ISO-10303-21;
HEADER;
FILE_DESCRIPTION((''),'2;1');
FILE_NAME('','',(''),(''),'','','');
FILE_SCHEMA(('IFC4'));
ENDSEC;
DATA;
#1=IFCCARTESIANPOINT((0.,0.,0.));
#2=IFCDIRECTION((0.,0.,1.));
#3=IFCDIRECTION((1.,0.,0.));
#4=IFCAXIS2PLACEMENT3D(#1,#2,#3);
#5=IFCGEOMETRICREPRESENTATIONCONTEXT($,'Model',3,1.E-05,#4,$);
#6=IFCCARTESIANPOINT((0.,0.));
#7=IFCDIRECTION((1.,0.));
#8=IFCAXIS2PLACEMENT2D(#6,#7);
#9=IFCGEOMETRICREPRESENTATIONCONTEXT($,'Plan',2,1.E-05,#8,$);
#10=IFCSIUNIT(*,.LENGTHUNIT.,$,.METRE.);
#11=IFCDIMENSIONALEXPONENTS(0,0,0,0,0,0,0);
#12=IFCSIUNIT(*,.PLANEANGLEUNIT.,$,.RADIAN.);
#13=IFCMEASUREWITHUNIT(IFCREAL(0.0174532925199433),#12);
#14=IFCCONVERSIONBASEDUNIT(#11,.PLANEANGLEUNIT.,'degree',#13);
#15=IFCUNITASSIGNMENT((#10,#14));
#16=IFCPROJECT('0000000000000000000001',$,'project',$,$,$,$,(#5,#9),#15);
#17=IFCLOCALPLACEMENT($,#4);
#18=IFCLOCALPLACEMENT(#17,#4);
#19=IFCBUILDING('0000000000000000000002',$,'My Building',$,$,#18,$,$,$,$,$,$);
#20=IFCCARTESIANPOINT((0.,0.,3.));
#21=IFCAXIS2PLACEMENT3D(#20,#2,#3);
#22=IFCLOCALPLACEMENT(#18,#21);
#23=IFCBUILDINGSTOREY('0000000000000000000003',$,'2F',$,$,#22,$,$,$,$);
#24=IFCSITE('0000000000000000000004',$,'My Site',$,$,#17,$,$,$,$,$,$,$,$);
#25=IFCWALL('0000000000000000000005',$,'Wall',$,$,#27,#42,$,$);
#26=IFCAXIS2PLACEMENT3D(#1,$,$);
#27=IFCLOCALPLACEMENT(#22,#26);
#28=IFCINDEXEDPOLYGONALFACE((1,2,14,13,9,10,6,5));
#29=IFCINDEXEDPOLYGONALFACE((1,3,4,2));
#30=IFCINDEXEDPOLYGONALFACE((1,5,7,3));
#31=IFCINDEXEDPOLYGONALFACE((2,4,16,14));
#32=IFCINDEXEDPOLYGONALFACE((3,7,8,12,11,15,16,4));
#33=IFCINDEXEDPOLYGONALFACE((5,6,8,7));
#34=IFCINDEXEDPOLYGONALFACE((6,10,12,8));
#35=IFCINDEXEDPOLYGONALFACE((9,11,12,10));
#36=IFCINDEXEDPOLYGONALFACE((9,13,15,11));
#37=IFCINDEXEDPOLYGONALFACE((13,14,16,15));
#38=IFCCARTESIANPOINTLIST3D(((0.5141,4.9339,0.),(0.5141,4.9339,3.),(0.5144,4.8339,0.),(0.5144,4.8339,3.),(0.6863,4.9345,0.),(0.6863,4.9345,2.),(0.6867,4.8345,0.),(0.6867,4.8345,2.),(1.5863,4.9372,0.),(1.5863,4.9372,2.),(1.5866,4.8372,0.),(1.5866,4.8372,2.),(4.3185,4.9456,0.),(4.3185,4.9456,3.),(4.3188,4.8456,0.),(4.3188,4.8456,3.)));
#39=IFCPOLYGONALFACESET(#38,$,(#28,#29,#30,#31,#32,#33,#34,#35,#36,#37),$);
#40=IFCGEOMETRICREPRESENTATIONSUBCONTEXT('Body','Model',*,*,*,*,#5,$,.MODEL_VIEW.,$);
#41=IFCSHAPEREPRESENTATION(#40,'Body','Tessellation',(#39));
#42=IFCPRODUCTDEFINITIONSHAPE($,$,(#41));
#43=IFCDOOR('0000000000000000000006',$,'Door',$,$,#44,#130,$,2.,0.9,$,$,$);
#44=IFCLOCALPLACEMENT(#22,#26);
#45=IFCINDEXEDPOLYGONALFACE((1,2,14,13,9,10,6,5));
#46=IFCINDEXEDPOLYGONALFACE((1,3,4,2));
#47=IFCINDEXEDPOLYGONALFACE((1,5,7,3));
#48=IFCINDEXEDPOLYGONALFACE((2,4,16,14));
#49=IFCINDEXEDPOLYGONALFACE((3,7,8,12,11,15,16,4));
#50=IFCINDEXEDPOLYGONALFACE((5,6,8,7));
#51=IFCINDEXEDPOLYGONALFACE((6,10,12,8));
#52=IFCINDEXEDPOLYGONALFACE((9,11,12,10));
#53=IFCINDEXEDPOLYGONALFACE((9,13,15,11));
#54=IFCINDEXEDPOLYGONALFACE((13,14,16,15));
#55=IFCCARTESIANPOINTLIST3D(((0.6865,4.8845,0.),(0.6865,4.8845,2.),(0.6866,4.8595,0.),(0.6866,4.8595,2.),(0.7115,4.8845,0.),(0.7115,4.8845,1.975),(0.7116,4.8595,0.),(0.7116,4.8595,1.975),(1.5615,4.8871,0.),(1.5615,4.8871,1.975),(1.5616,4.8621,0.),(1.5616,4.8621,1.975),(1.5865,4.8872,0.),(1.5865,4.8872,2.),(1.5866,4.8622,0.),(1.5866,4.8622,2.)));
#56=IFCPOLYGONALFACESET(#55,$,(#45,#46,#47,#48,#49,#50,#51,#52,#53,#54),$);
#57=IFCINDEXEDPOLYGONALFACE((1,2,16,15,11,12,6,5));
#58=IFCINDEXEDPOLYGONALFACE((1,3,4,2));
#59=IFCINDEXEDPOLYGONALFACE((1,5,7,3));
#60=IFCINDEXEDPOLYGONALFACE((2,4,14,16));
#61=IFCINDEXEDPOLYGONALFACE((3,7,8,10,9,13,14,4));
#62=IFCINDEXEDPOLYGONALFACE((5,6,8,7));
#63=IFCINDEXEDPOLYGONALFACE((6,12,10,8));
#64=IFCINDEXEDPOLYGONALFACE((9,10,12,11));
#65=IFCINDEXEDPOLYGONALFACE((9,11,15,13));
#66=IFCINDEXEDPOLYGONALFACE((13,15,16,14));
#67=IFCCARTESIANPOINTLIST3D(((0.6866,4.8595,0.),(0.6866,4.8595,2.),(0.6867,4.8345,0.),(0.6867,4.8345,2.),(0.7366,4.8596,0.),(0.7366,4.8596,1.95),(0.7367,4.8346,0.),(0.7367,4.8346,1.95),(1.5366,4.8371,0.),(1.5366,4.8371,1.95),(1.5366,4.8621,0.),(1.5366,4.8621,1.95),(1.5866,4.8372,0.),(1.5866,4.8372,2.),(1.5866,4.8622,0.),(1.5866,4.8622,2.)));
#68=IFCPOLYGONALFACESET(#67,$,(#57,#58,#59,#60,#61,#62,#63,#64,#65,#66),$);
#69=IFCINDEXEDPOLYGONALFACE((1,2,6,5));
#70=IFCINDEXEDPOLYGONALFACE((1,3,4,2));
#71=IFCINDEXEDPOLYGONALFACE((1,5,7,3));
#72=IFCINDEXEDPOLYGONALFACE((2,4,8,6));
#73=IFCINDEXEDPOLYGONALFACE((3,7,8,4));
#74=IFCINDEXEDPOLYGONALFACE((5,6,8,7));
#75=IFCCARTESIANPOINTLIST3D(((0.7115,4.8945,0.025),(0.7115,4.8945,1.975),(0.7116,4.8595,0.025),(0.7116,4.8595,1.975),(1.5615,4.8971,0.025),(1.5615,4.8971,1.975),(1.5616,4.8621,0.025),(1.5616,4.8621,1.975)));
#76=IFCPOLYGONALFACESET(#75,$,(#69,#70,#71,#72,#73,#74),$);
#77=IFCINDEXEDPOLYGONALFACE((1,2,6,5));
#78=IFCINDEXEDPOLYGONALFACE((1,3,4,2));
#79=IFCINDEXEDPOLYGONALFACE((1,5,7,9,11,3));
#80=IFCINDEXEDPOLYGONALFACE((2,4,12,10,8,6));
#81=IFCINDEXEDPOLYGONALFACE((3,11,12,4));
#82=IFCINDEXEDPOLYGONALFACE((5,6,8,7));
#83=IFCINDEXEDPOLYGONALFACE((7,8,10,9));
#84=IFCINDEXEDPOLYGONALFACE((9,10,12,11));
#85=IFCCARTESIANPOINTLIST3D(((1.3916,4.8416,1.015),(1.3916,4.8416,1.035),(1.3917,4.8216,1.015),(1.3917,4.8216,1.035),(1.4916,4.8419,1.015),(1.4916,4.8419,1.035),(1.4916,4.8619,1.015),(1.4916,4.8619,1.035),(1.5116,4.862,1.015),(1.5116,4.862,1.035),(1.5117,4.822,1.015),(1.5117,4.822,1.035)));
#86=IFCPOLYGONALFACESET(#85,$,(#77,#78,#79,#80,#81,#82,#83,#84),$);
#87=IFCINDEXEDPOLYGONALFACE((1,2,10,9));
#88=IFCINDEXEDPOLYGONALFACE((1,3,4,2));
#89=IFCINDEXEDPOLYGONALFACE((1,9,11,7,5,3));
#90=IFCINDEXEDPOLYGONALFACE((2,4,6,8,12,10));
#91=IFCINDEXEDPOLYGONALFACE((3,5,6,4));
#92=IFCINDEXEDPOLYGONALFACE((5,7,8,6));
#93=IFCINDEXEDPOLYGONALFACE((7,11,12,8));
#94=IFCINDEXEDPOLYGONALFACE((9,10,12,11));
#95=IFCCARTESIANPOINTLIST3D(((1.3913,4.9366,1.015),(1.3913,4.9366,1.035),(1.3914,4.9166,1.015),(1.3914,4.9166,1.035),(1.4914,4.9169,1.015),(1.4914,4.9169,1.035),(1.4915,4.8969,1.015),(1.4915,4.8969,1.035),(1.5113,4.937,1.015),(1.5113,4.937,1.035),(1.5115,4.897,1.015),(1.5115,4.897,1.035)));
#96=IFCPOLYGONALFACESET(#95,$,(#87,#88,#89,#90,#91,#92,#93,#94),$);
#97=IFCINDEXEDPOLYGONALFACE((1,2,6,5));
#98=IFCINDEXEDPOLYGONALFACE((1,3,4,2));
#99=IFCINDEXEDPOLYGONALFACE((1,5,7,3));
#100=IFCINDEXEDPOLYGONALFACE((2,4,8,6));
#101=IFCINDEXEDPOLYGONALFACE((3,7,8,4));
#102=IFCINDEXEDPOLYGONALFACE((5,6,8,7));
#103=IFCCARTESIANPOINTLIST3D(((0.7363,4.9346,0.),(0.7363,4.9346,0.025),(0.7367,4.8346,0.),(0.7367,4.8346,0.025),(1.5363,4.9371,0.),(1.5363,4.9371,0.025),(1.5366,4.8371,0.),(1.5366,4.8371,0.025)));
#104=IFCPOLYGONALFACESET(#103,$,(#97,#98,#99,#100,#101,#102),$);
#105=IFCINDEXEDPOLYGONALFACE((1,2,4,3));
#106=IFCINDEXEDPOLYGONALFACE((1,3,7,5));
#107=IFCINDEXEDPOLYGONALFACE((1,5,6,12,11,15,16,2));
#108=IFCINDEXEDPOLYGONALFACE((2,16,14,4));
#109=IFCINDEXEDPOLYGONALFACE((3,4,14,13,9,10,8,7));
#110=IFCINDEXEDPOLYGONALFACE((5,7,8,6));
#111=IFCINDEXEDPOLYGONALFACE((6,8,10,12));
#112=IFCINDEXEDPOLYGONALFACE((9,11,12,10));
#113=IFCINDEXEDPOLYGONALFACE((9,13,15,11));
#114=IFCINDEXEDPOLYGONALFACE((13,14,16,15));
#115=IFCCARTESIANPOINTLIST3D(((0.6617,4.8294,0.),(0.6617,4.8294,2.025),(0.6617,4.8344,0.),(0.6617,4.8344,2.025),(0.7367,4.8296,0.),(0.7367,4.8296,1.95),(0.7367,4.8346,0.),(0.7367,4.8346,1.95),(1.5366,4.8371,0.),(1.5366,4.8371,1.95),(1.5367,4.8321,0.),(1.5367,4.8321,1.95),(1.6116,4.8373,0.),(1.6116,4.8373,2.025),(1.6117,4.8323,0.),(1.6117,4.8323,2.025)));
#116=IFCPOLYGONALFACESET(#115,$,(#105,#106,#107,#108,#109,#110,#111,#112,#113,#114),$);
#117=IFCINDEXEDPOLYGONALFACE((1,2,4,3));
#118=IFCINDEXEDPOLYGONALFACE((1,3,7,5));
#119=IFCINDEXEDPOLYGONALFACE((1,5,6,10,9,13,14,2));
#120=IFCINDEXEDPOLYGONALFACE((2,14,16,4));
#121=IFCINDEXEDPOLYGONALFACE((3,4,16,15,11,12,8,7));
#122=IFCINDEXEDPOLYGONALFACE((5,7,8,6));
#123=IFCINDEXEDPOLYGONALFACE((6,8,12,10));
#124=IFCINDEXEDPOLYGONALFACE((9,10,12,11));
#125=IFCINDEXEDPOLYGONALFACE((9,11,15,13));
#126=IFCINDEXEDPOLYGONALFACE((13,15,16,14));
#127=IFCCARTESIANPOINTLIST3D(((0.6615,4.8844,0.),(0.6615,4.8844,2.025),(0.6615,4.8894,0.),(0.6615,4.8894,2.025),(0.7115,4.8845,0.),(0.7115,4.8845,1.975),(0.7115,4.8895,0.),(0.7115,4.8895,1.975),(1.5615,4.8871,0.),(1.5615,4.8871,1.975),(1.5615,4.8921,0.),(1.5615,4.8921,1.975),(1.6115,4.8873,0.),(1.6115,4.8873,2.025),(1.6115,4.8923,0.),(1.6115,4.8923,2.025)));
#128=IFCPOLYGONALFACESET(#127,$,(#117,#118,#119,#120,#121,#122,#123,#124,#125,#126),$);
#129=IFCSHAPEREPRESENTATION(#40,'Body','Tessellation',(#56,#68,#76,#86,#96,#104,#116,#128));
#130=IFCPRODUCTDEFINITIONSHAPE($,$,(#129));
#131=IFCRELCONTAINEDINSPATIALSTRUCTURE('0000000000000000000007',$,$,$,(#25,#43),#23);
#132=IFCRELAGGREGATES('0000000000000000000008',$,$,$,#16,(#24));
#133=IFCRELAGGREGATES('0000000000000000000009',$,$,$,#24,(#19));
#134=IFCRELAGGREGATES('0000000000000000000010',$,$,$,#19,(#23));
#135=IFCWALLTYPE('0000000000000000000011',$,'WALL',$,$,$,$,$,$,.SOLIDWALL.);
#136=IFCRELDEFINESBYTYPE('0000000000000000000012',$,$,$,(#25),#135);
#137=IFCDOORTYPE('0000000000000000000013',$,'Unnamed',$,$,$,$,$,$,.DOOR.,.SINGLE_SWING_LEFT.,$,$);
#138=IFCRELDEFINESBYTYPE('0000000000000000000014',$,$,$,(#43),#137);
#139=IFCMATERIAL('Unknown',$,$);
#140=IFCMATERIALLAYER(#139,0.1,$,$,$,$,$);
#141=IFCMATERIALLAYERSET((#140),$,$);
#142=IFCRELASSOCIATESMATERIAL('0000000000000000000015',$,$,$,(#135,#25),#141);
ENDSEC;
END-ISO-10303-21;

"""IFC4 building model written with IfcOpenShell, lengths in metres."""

from ifc_helpers import new_model, entity, si_unit, converted_unit, frame, origin_with_axes, origin_2d_with_axis, place, context, subcontext, project, spatial, line, indexed_curve, outline, extrude, shape, source, transform, mapped, material, layer, layer_set, layer_usage, type_object, type_shapes, element, fill, save


model = new_model("IFC4")

# Units and contexts
model_context = context("Model", 3, precision=1e-05, world=origin_with_axes())
plan_context = context("Plan", 2, precision=1e-05, world=origin_2d_with_axis())
body_context_1 = subcontext(model_context, "Body", "Model", "MODEL_VIEW")
body_context_2 = subcontext(plan_context, "Body", "Plan", "PLAN_VIEW")
ifc_project = project(units=[si_unit("LENGTHUNIT", "METRE"), converted_unit("PLANEANGLEUNIT", "degree", entity("IfcReal", 0.0174532925199433), si_unit("PLANEANGLEUNIT", "RADIAN"), dimensions=[0, 0, 0, 0, 0, 0, 0])], contexts=[model_context, plan_context])

# Site, building, storey
site_placement = place(None, origin_with_axes())
site = spatial("IfcSite", under=ifc_project, at=site_placement, Name="My Site")
building_placement = place(site_placement, origin_with_axes())
building = spatial("IfcBuilding", under=site, at=building_placement, Name="My Building")
storey_placement = place(building_placement, frame((0.0, 0.0, 3.0), z_axis=(0.0, 0.0, 1.0), x_axis=(1.0, 0.0, 0.0)))
storey = spatial("IfcBuildingStorey", under=building, at=storey_placement, Name="2F")

# Shared definitions
ifc_material = material(Name="Unknown")

# Shared definitions
ifc_layer_1 = layer(ifc_material, 0.1)
ifc_layer_set_1 = layer_set([ifc_layer_1])
wall_type = type_object("IfcWallType", Name="WALL", PredefinedType="SOLIDWALL", material=ifc_layer_set_1)

# Wall, opening, door
ifc_layer_usage_1 = layer_usage(ifc_layer_set_1, "AXIS2", "POSITIVE", 0.0)
wall_1_placement = place(storey_placement, frame((0.5144, 4.8339, 0.0), z_axis=(0.0, 0.0, 1.0), x_axis=(0.999995, 0.003068, 0.0)))
wall_1 = element("IfcWall", 1, at=wall_1_placement, inside=storey, type_object=wall_type, material=ifc_layer_usage_1, Name="Wall", context=body_context_1, shape_type="SweptSolid", body=[
    extrude(outline(indexed_curve([(0.0, 0.0), (0.0, 0.1), (3.8044, 0.1), (3.8044, 0.0)], segments=[line(1, 2, 3, 4, 1)])), origin_with_axes(), (0.0, 0.0, 1.0), 3.0),
])
shared_shape_1 = source(origin_with_axes(), body_context_1, "Body", "SweptSolid", [
    extrude(outline(indexed_curve([(0.0, 0.0), (0.9, 0.0), (0.9, 2.0), (0.0, 2.0)], segments=[line(1, 2, 3, 4, 1)])), frame((0.0, -0.6, 0.0), z_axis=(0.0, -1.0, 0.0), x_axis=(1.0, 0.0, 0.0)), (0.0, 0.0, -1.0), 1.2),
])
opening_1_placement = place(wall_1_placement, frame((0.1723, 0.0, 0.0), z_axis=(0.0, 0.0, 1.0), x_axis=(1.0, 0.0, 0.0)))
opening_1 = element("IfcOpeningElement", 2, at=opening_1_placement, cuts=wall_1, PredefinedType="OPENING", context=body_context_1, shape_type="MappedRepresentation", body=[
    mapped(shared_shape_1, transform((0.0, 0.0, 0.0), x_axis=(1.0, 0.0, 0.0), y_axis=(0.0, 1.0, 0.0), z_axis=(0.0, 0.0, 1.0), scale=1.0)),
])
door_type = type_object("IfcDoorType", Name="Unnamed", OperationType="SINGLE_SWING_LEFT", PredefinedType="DOOR")
shared_shape_2 = source(origin_with_axes(), body_context_1, "Body", "SweptSolid", [
    extrude(outline(indexed_curve([(0.0, 0.0), (0.0, 2.0), (0.9, 2.0), (0.9, 0.0), (0.875, 0.0), (0.875, 1.975), (0.025, 1.975), (0.025, 0.0)], segments=[line(1, 2, 3, 4, 5, 6, 7, 8, 1)])), frame((0.0, 0.025, 0.0), z_axis=(0.0, -1.0, 0.0), x_axis=(1.0, 0.0, 0.0)), (0.0, 0.0, -1.0), 0.025),
    extrude(outline(indexed_curve([(0.0, 0.0), (0.0, 2.0), (0.9, 2.0), (0.9, 0.0), (0.85, 0.0), (0.85, 1.95), (0.05, 1.95), (0.05, 0.0)], segments=[line(1, 2, 3, 4, 5, 6, 7, 8, 1)])), frame((0.0, 0.0, 0.0), z_axis=(0.0, -1.0, 0.0), x_axis=(1.0, 0.0, 0.0)), (0.0, 0.0, -1.0), 0.025),
    extrude(outline(indexed_curve([(0.0, 0.0), (0.85, 0.0), (0.85, 0.035), (0.0, 0.035)], segments=[line(1, 2, 3, 4, 1)])), frame((0.025, 0.025, 0.025), z_axis=(0.0, 0.0, 1.0), x_axis=(1.0, 0.0, 0.0)), (0.0, 0.0, 1.0), 1.95),
    extrude(outline(indexed_curve([(0.0, 0.0), (0.0, -0.04), (-0.12, -0.04), (-0.12, -0.02), (-0.02, -0.02), (-0.02, 0.0)], segments=[line(1, 2, 3, 4, 5, 6, 1)])), frame((0.825, 0.025, 1.015), z_axis=(0.0, 0.0, 1.0), x_axis=(1.0, 0.0, 0.0)), (0.0, 0.0, 1.0), 0.02),
    extrude(outline(indexed_curve([(0.0, 0.0), (0.0, 0.04), (-0.12, 0.04), (-0.12, 0.02), (-0.02, 0.02), (-0.02, 0.0)], segments=[line(1, 2, 3, 4, 5, 6, 1)])), frame((0.825, 0.06, 1.015), z_axis=(0.0, 0.0, 1.0), x_axis=(1.0, 0.0, 0.0)), (0.0, 0.0, 1.0), 0.02),
    extrude(outline(indexed_curve([(0.0, 0.0), (0.8, 0.0), (0.8, 0.1), (0.0, 0.1)], segments=[line(1, 2, 3, 4, 1)])), frame((0.05, 0.0, 0.0), z_axis=(0.0, 0.0, 1.0), x_axis=(1.0, 0.0, 0.0)), (0.0, 0.0, 1.0), 0.025),
    extrude(outline(indexed_curve([(0.0, 0.0), (0.0, 2.025), (0.95, 2.025), (0.95, 0.0), (0.875, 0.0), (0.875, 1.95), (0.075, 1.95), (0.075, 0.0)], segments=[line(1, 2, 3, 4, 5, 6, 7, 8, 1)])), frame((-0.025, -0.005, 0.0), z_axis=(0.0, -1.0, 0.0), x_axis=(1.0, 0.0, 0.0)), (0.0, 0.0, -1.0), 0.005),
    extrude(outline(indexed_curve([(0.0, 0.0), (0.0, 2.025), (0.95, 2.025), (0.95, 0.0), (0.9, 0.0), (0.9, 1.975), (0.05, 1.975), (0.05, 0.0)], segments=[line(1, 2, 3, 4, 5, 6, 7, 8, 1)])), frame((-0.025, 0.05, 0.0), z_axis=(0.0, -1.0, 0.0), x_axis=(1.0, 0.0, 0.0)), (0.0, 0.0, -1.0), 0.005),
])
shared_shape_3 = source(origin_with_axes(), body_context_2, "Body", "Curve2D", [
    entity("IfcIndexedPolyCurve", entity("IfcCartesianPointList2D", [[0.0, 0.0], [0.0, 0.05], [0.025, 0.05], [0.025, 0.025], [0.05, 0.025], [0.05, 0.0]]), [entity("IfcLineIndex", [1, 2, 3, 4, 5, 6, 1])]),
    entity("IfcIndexedPolyCurve", entity("IfcCartesianPointList2D", [[0.9, 0.0], [0.9, 0.05], [0.875, 0.05], [0.875, 0.025], [0.85, 0.025], [0.85, 0.0]]), [entity("IfcLineIndex", [1, 2, 3, 4, 5, 6, 1])]),
    entity("IfcTrimmedCurve", entity("IfcEllipse", entity("IfcAxis2Placement2D", entity("IfcCartesianPoint", [0.06, 0.05]), entity("IfcDirection", [1.0, 0.0])), 0.815, 0.85), [entity("IfcCartesianPoint", [0.875, 0.05])], [entity("IfcCartesianPoint", [0.06, 0.9])], True, "CARTESIAN"),
    entity("IfcIndexedPolyCurve", entity("IfcCartesianPointList2D", [[0.025, 0.05], [0.06, 0.05], [0.06, 0.9], [0.025, 0.9]]), [entity("IfcLineIndex", [1, 2, 3, 4, 1])]),
])
type_shapes(door_type, [shared_shape_2, shared_shape_3])
door_1_placement = place(opening_1_placement, frame((0.0, 0.0, 0.0), z_axis=(0.0, 0.0, 1.0), x_axis=(1.0, 0.0, 0.0)))
door_1 = element("IfcDoor", 3, at=door_1_placement, inside=storey, type_object=door_type, Name="Door", OverallHeight=2.0, OverallWidth=0.9, shapes=[
    shape(body_context_1, "Body", "MappedRepresentation", [mapped(shared_shape_2, transform((0.0, 0.0, 0.0), x_axis=(1.0, 0.0, 0.0), y_axis=(0.0, 1.0, 0.0), z_axis=(0.0, 0.0, 1.0), scale=1.0))]),
    shape(body_context_2, "Body", "MappedRepresentation", [mapped(shared_shape_3, transform((0.0, 0.0, 0.0), x_axis=(1.0, 0.0, 0.0), y_axis=(0.0, 1.0, 0.0), z_axis=(0.0, 0.0, 1.0), scale=1.0))]),
])
fill(opening_1, door_1)

save(model, "model.ifc")
